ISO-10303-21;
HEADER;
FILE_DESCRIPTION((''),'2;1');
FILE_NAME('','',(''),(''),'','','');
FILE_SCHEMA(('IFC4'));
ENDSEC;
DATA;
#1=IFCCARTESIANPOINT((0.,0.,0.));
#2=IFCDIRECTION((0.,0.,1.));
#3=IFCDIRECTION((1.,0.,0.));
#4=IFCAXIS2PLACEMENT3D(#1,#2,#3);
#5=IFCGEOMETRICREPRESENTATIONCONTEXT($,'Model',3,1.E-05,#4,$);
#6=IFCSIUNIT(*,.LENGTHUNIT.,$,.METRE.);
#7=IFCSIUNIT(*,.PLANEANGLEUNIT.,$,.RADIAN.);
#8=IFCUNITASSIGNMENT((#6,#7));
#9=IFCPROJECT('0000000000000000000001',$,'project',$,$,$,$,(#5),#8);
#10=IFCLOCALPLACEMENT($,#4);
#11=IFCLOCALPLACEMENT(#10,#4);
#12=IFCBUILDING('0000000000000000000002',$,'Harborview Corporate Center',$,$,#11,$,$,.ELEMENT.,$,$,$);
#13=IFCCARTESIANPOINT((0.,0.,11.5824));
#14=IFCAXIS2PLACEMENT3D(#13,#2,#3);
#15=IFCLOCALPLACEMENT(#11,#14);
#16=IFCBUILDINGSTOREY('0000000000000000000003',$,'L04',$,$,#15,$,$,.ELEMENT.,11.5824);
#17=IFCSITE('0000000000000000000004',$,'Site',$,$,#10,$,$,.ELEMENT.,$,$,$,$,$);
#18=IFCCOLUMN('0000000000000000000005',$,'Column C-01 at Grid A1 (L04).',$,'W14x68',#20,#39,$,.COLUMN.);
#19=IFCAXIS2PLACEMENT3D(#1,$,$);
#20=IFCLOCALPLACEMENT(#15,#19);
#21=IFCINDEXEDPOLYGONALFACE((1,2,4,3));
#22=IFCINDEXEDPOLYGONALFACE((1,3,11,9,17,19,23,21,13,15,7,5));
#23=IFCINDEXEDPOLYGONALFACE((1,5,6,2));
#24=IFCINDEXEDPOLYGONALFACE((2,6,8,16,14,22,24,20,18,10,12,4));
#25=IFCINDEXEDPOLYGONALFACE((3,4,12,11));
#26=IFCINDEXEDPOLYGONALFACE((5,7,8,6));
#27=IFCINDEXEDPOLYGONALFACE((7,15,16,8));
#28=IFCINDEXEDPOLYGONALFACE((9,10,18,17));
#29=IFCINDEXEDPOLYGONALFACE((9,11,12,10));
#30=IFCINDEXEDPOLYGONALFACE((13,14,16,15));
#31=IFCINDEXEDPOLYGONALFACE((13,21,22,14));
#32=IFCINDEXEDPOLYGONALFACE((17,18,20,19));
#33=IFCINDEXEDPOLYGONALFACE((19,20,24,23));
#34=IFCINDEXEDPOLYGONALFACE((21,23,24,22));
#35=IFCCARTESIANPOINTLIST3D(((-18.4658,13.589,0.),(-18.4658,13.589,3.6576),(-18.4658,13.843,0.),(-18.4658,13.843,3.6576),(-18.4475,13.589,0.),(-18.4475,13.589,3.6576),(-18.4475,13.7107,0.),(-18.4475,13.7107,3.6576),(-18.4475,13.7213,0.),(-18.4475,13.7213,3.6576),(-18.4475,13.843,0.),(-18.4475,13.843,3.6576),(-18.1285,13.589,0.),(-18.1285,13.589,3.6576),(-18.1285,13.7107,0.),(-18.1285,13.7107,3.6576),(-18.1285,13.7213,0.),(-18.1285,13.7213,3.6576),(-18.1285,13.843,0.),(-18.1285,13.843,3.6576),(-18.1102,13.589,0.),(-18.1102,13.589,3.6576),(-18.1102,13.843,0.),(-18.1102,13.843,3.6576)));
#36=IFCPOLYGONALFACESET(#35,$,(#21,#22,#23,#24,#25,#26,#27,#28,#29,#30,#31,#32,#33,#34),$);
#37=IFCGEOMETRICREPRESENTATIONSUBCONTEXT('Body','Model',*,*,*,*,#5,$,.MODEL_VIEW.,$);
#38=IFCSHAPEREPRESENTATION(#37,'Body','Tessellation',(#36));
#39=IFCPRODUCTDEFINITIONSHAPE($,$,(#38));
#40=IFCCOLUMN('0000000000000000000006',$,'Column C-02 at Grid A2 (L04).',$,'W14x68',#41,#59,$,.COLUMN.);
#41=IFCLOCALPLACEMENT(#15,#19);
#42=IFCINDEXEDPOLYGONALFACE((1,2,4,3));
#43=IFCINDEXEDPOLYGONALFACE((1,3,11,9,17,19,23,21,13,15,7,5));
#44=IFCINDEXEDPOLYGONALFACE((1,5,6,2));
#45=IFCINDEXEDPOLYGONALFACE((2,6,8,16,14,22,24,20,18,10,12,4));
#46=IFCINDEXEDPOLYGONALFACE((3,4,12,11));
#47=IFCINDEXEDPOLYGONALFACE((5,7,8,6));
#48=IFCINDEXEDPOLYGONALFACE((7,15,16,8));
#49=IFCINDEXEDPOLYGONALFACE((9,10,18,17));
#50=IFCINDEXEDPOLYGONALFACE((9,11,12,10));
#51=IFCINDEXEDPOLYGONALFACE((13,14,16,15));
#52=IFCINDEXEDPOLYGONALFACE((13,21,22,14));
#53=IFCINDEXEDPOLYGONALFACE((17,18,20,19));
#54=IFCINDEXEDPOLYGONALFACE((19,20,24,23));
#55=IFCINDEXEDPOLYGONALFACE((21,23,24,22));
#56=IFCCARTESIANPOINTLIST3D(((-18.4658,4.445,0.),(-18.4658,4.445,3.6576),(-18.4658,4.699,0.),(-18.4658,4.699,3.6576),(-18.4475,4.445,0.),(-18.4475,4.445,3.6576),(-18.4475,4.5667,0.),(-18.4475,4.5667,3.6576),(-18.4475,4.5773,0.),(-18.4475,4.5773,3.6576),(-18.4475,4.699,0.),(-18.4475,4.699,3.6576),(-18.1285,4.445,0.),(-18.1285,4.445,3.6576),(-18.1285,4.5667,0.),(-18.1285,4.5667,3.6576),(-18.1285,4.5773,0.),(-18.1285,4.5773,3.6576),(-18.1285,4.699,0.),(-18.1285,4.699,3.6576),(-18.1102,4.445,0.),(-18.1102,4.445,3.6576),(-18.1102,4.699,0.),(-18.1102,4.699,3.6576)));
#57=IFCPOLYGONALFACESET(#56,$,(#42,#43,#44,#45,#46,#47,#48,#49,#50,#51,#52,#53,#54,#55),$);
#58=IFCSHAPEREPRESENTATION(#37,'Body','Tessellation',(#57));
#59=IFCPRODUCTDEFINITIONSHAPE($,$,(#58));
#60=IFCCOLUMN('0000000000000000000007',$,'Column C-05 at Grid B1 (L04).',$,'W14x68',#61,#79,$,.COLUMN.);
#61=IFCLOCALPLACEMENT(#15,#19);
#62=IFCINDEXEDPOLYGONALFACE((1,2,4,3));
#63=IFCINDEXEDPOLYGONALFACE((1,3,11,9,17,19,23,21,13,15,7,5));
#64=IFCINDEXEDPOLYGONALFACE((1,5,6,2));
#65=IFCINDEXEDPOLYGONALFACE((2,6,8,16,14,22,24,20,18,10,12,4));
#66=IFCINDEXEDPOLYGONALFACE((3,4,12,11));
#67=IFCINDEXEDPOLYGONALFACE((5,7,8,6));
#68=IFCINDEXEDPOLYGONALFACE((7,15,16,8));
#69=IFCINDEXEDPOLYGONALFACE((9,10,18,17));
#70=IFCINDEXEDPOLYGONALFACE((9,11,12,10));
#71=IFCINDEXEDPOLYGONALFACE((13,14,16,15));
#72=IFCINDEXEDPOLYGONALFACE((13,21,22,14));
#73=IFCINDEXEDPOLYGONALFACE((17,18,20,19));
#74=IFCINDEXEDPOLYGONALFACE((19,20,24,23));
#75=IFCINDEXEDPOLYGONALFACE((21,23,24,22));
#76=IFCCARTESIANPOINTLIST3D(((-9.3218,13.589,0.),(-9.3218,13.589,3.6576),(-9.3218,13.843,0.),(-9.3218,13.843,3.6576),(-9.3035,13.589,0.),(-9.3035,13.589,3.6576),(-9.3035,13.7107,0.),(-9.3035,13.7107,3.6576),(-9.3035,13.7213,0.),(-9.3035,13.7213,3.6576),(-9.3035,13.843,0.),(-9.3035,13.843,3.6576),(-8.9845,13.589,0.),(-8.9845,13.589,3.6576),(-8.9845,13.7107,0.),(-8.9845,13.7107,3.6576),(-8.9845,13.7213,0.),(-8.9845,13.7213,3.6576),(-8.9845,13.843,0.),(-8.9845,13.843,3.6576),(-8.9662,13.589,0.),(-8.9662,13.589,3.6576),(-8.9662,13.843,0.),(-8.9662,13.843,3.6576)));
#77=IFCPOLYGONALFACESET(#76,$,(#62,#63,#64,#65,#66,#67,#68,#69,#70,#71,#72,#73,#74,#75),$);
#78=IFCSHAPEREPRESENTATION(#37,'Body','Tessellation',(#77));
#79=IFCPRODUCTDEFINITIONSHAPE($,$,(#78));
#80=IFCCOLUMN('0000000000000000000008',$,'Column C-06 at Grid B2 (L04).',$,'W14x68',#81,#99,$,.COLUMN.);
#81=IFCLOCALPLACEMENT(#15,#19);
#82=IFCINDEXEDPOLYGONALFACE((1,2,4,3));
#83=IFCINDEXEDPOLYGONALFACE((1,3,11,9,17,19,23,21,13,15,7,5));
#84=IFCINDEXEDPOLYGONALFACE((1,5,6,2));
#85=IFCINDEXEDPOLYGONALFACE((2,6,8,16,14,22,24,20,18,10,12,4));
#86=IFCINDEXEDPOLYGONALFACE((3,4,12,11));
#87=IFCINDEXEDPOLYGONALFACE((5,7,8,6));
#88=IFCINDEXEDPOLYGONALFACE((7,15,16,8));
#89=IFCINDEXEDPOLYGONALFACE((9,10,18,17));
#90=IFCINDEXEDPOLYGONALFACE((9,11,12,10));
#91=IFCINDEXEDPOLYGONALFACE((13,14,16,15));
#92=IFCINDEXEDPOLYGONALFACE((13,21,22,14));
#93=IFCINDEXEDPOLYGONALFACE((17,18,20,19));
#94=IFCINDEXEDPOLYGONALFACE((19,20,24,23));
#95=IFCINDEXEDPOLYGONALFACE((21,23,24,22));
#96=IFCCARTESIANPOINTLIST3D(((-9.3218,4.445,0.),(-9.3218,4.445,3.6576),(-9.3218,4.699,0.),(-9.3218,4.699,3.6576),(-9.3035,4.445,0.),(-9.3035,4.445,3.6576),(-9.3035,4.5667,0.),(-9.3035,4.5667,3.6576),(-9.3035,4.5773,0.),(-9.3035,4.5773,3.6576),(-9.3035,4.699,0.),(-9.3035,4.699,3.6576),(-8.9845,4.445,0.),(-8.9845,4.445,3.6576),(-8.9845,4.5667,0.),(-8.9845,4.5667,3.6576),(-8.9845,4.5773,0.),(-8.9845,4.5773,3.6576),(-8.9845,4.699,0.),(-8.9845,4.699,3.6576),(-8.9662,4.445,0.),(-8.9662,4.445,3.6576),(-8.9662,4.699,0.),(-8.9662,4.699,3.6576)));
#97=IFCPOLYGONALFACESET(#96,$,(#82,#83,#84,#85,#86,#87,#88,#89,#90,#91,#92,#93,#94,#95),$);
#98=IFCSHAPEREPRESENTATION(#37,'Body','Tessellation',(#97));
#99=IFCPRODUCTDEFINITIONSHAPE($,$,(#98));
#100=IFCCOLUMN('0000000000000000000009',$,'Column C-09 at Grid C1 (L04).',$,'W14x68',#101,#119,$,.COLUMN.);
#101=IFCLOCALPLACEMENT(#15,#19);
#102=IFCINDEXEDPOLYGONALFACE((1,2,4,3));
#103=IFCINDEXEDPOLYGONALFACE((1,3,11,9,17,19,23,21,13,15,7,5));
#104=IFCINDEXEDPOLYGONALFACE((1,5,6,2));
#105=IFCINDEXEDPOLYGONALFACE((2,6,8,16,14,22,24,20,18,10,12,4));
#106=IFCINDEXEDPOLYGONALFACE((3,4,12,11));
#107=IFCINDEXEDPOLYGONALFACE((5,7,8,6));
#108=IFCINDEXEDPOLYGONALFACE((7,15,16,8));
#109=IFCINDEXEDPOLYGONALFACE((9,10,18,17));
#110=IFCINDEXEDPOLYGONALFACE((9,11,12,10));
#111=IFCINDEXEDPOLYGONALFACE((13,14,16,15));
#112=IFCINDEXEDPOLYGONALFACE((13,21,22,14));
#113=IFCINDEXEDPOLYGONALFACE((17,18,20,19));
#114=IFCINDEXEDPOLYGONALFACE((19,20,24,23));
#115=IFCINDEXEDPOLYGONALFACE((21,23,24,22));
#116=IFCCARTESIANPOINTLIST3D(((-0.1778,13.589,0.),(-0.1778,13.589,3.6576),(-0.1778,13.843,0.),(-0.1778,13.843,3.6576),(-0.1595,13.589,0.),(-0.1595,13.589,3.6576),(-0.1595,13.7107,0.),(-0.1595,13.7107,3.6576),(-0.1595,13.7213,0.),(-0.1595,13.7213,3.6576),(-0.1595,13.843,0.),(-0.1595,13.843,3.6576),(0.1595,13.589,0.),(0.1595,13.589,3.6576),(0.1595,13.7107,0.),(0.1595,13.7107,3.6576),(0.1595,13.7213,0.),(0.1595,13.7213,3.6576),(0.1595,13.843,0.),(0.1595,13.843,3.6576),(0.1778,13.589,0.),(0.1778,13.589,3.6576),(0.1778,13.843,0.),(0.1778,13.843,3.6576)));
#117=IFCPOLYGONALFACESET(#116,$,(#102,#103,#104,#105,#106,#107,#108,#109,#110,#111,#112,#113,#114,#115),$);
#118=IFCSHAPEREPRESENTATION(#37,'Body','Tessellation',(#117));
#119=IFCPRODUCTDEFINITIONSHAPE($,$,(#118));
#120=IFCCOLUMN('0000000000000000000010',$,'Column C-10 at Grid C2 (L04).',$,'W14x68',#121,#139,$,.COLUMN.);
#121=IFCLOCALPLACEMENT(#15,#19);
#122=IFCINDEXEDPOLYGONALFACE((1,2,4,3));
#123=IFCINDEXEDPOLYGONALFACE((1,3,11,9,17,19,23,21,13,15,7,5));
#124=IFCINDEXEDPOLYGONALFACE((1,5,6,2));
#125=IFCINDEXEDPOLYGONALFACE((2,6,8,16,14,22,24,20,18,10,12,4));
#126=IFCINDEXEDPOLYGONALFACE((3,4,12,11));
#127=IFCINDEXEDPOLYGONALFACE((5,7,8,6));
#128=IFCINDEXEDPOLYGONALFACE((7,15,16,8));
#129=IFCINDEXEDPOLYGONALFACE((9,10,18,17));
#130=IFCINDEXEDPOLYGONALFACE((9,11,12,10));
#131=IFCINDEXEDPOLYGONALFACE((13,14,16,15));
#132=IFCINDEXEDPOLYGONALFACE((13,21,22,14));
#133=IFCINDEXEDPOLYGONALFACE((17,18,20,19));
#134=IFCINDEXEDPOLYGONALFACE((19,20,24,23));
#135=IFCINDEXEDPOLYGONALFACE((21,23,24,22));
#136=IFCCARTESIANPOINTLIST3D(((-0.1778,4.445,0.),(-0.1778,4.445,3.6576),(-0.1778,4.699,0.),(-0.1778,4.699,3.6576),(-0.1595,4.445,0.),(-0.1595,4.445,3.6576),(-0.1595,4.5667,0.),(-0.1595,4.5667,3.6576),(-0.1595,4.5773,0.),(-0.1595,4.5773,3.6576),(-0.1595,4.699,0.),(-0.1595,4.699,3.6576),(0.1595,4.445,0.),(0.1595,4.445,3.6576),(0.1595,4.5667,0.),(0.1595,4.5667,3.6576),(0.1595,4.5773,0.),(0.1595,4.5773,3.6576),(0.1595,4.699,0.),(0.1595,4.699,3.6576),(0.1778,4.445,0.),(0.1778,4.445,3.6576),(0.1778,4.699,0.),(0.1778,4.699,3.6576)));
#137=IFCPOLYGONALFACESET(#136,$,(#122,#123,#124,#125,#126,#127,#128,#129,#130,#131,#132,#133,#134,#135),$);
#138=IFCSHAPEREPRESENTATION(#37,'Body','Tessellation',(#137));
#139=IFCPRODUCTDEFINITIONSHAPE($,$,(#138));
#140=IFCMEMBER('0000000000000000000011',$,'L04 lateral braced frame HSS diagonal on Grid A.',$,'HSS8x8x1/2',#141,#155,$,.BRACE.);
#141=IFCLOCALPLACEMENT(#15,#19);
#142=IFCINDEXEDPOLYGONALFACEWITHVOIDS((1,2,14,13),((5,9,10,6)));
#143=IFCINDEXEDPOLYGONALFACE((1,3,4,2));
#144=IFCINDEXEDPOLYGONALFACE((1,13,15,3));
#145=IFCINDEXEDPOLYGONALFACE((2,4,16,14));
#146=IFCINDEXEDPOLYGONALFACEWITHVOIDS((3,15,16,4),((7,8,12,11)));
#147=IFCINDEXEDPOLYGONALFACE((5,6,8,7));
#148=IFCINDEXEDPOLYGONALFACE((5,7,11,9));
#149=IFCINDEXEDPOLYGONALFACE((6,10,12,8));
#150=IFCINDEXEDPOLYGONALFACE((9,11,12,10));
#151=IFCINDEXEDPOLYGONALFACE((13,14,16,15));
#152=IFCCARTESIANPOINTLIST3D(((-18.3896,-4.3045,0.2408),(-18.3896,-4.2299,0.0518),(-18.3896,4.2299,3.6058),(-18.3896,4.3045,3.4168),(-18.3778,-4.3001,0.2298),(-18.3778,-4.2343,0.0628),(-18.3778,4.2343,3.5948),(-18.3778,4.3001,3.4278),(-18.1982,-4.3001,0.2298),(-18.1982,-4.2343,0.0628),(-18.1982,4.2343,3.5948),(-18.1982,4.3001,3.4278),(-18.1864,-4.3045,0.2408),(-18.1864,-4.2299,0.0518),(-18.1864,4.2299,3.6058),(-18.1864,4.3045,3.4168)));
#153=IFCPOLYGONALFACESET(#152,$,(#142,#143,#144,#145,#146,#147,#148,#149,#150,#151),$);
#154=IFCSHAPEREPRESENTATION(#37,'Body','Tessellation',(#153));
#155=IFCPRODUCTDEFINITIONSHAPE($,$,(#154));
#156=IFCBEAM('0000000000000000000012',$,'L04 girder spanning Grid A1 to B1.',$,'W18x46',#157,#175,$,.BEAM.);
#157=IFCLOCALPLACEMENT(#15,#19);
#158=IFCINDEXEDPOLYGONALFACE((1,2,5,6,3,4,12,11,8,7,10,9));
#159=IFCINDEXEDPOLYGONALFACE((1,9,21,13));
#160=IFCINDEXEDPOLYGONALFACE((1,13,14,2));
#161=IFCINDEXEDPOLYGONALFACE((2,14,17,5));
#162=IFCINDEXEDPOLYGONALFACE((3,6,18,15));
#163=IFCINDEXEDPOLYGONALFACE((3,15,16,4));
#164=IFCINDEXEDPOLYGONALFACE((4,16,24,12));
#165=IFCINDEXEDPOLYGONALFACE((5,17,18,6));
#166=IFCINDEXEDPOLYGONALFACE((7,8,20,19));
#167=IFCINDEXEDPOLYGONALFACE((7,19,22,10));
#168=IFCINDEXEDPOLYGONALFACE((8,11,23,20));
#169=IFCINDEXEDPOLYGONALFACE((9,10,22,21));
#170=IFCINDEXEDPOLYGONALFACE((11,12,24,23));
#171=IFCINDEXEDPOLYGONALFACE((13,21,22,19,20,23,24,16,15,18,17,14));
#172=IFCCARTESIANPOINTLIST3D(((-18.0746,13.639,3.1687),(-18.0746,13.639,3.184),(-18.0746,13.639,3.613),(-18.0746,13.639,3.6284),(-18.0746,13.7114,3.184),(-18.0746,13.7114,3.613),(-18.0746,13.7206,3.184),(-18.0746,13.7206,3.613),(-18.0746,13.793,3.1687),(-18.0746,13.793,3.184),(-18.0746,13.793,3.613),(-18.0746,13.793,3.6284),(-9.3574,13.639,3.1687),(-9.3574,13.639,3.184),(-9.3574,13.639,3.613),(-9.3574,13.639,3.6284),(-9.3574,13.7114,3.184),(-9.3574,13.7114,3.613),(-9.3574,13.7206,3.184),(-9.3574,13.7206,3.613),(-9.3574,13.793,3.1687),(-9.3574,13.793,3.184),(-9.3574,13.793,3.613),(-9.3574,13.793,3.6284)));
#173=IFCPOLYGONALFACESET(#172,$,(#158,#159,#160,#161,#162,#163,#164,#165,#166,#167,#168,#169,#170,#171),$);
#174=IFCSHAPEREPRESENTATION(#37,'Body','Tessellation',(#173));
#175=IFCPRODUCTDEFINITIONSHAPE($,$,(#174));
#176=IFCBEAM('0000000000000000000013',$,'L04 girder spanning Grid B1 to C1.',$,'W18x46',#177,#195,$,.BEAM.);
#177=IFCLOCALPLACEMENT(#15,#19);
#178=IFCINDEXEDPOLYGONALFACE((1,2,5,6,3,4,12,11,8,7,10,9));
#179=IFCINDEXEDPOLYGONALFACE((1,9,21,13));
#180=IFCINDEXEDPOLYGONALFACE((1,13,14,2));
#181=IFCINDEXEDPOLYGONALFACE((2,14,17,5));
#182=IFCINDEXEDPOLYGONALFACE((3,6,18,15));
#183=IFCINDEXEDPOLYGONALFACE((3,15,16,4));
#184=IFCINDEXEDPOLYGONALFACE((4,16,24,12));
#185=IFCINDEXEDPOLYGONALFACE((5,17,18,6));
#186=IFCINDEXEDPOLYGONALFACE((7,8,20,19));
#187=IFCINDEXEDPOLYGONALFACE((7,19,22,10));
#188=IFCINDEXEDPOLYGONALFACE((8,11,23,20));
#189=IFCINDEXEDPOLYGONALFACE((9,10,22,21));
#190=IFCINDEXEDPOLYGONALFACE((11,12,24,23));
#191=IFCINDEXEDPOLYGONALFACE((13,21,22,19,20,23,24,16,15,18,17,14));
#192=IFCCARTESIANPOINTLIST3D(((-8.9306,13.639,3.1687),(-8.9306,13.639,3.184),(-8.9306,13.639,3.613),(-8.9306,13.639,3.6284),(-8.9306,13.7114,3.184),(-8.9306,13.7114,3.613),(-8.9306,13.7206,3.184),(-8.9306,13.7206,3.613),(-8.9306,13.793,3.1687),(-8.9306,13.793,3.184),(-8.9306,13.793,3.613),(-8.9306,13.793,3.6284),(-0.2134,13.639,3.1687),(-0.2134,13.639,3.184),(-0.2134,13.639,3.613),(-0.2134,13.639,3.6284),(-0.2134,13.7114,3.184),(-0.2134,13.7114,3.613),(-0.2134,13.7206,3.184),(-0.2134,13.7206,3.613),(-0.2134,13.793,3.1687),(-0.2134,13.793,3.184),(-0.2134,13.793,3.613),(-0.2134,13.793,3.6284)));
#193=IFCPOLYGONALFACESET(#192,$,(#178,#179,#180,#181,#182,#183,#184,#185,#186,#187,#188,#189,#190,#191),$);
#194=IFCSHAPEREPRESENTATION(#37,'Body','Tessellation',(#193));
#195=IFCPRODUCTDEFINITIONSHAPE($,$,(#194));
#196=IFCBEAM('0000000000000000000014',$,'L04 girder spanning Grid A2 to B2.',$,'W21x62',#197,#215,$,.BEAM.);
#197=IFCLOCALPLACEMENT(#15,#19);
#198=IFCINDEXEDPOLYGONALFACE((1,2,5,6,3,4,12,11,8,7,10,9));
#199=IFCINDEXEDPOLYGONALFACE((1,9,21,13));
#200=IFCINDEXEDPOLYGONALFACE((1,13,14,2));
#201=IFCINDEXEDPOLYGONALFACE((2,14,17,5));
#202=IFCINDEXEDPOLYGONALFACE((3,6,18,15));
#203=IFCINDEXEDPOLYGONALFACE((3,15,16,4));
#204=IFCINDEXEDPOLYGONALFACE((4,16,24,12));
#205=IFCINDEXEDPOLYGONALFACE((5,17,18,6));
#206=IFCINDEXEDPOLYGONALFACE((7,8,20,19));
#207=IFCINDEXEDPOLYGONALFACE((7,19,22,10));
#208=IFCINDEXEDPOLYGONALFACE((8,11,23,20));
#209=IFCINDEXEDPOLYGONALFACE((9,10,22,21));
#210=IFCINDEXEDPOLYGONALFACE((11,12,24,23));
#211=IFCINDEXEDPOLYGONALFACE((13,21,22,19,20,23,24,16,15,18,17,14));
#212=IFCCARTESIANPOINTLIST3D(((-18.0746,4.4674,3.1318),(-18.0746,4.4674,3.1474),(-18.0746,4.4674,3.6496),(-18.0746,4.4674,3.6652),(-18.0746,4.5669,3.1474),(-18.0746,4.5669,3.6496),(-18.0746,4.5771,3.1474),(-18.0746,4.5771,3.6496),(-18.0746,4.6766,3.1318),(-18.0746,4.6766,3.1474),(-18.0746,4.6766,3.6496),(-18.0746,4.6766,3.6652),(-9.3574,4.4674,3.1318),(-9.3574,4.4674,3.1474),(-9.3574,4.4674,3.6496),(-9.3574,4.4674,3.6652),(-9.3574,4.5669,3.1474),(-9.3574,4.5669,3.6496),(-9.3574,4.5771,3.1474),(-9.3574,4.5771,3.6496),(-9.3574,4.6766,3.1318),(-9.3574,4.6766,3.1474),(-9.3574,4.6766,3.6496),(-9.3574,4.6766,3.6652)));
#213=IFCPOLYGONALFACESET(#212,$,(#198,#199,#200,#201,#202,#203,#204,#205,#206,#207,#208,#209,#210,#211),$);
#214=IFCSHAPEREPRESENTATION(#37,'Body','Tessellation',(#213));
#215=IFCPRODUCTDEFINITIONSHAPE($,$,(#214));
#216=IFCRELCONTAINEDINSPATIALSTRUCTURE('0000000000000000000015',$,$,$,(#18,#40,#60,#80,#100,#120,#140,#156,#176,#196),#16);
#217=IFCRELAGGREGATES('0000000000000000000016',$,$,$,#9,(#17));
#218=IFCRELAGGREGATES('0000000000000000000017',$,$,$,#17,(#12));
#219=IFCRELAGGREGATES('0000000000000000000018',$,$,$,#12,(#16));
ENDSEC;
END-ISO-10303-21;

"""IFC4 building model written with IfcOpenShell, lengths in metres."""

from ifc_helpers import new_model, si_unit, frame, origin_with_axes, place, context, subcontext, project, spatial, hollow_rectangle, i_section, extrude, element, save


model = new_model("IFC4")

# Units and contexts
model_context = context("Model", 3, precision=1e-05, world=origin_with_axes())
body_context = subcontext(model_context, "Body", "Model", "MODEL_VIEW")
ifc_project = project(units=[si_unit("LENGTHUNIT", "METRE"), si_unit("PLANEANGLEUNIT", "RADIAN")], contexts=[model_context])

# Site, building, storey
site_placement = place(None, origin_with_axes())
site = spatial("IfcSite", under=ifc_project, at=site_placement, Name="Site", CompositionType="ELEMENT")
building_placement = place(site_placement, origin_with_axes())
building = spatial("IfcBuilding", under=site, at=building_placement, Name="Harborview Corporate Center", CompositionType="ELEMENT")
storey_placement = place(building_placement, frame((0.0, 0.0, 11.5824), z_axis=(0.0, 0.0, 1.0), x_axis=(1.0, 0.0, 0.0)))
storey = spatial("IfcBuildingStorey", under=building, at=storey_placement, Name="L04", CompositionType="ELEMENT", Elevation=11.5824)

# Columns
for number, where, z_axis, x_axis, name in (
    (1, (-18.288, 13.716, 0.0), (0.0, 0.0, 1.0), (0.0, 1.0, 0.0), "Column C-01 at Grid A1 (L04)."),
    (2, (-18.288, 4.572, 0.0), (0.0, 0.0, 1.0), (0.0, 1.0, 0.0), "Column C-02 at Grid A2 (L04)."),
    (3, (-9.144, 13.716, 0.0), (0.0, 0.0, 1.0), (0.0, 1.0, 0.0), "Column C-05 at Grid B1 (L04)."),
    (4, (-9.144, 4.572, 0.0), (0.0, 0.0, 1.0), (0.0, 1.0, 0.0), "Column C-06 at Grid B2 (L04)."),
    (5, (0.0, 13.716, 0.0), (0.0, 0.0, 1.0), (0.0, 1.0, 0.0), "Column C-09 at Grid C1 (L04)."),
    (6, (0.0, 4.572, 0.0), (0.0, 0.0, 1.0), (0.0, 1.0, 0.0), "Column C-10 at Grid C2 (L04)."),
):
    element("IfcColumn", number, at=place(storey_placement, frame(where, z_axis=z_axis, x_axis=x_axis)), inside=storey, Name=name, ObjectType="W14x68", PredefinedType="COLUMN", context=body_context, shape_type="SweptSolid", body=[
        extrude(i_section(OverallWidth=0.254, OverallDepth=0.3556, WebThickness=0.0105, FlangeThickness=0.0183), origin_with_axes(), (0.0, 0.0, 1.0), 3.6576),
    ])

# Member
member_placement = place(storey_placement, frame((-18.288, -4.2672, 0.1463), z_axis=(0.0, 0.930298, 0.366803), x_axis=(-1.0, 0.0, 0.0)))
element("IfcMember", 7, at=member_placement, inside=storey, Name="L04 lateral braced frame HSS diagonal on Grid A.", ObjectType="HSS8x8x1/2", PredefinedType="BRACE", context=body_context, shape_type="SweptSolid", body=[
    extrude(hollow_rectangle(XDim=0.2032, YDim=0.2032, WallThickness=0.0118), origin_with_axes(), (0.0, 0.0, 1.0), 9.1738),
])

# Beams
beam_1_placement = place(storey_placement, frame((-18.0746, 13.716, 3.3985), z_axis=(1.0, 0.0, 0.0), x_axis=(0.0, 1.0, 0.0)))
element("IfcBeam", 8, at=beam_1_placement, inside=storey, Name="L04 girder spanning Grid A1 to B1.", ObjectType="W18x46", PredefinedType="BEAM", context=body_context, shape_type="SweptSolid", body=[
    extrude(i_section(OverallWidth=0.1539, OverallDepth=0.4597, WebThickness=0.0091, FlangeThickness=0.0154), origin_with_axes(), (0.0, 0.0, 1.0), 8.7173),
])
beam_2_placement = place(storey_placement, frame((-8.9306, 13.716, 3.3985), z_axis=(1.0, 0.0, 0.0), x_axis=(0.0, 1.0, 0.0)))
element("IfcBeam", 9, at=beam_2_placement, inside=storey, Name="L04 girder spanning Grid B1 to C1.", ObjectType="W18x46", PredefinedType="BEAM", context=body_context, shape_type="SweptSolid", body=[
    extrude(i_section(OverallWidth=0.1539, OverallDepth=0.4597, WebThickness=0.0091, FlangeThickness=0.0154), origin_with_axes(), (0.0, 0.0, 1.0), 8.7173),
])
beam_3_placement = place(storey_placement, frame((-18.0746, 4.572, 3.3985), z_axis=(1.0, 0.0, 0.0), x_axis=(0.0, 1.0, 0.0)))
element("IfcBeam", 10, at=beam_3_placement, inside=storey, Name="L04 girder spanning Grid A2 to B2.", ObjectType="W21x62", PredefinedType="BEAM", context=body_context, shape_type="SweptSolid", body=[
    extrude(i_section(OverallWidth=0.2093, OverallDepth=0.5334, WebThickness=0.0102, FlangeThickness=0.0156), origin_with_axes(), (0.0, 0.0, 1.0), 8.7173),
])

save(model, "model.ifc")
